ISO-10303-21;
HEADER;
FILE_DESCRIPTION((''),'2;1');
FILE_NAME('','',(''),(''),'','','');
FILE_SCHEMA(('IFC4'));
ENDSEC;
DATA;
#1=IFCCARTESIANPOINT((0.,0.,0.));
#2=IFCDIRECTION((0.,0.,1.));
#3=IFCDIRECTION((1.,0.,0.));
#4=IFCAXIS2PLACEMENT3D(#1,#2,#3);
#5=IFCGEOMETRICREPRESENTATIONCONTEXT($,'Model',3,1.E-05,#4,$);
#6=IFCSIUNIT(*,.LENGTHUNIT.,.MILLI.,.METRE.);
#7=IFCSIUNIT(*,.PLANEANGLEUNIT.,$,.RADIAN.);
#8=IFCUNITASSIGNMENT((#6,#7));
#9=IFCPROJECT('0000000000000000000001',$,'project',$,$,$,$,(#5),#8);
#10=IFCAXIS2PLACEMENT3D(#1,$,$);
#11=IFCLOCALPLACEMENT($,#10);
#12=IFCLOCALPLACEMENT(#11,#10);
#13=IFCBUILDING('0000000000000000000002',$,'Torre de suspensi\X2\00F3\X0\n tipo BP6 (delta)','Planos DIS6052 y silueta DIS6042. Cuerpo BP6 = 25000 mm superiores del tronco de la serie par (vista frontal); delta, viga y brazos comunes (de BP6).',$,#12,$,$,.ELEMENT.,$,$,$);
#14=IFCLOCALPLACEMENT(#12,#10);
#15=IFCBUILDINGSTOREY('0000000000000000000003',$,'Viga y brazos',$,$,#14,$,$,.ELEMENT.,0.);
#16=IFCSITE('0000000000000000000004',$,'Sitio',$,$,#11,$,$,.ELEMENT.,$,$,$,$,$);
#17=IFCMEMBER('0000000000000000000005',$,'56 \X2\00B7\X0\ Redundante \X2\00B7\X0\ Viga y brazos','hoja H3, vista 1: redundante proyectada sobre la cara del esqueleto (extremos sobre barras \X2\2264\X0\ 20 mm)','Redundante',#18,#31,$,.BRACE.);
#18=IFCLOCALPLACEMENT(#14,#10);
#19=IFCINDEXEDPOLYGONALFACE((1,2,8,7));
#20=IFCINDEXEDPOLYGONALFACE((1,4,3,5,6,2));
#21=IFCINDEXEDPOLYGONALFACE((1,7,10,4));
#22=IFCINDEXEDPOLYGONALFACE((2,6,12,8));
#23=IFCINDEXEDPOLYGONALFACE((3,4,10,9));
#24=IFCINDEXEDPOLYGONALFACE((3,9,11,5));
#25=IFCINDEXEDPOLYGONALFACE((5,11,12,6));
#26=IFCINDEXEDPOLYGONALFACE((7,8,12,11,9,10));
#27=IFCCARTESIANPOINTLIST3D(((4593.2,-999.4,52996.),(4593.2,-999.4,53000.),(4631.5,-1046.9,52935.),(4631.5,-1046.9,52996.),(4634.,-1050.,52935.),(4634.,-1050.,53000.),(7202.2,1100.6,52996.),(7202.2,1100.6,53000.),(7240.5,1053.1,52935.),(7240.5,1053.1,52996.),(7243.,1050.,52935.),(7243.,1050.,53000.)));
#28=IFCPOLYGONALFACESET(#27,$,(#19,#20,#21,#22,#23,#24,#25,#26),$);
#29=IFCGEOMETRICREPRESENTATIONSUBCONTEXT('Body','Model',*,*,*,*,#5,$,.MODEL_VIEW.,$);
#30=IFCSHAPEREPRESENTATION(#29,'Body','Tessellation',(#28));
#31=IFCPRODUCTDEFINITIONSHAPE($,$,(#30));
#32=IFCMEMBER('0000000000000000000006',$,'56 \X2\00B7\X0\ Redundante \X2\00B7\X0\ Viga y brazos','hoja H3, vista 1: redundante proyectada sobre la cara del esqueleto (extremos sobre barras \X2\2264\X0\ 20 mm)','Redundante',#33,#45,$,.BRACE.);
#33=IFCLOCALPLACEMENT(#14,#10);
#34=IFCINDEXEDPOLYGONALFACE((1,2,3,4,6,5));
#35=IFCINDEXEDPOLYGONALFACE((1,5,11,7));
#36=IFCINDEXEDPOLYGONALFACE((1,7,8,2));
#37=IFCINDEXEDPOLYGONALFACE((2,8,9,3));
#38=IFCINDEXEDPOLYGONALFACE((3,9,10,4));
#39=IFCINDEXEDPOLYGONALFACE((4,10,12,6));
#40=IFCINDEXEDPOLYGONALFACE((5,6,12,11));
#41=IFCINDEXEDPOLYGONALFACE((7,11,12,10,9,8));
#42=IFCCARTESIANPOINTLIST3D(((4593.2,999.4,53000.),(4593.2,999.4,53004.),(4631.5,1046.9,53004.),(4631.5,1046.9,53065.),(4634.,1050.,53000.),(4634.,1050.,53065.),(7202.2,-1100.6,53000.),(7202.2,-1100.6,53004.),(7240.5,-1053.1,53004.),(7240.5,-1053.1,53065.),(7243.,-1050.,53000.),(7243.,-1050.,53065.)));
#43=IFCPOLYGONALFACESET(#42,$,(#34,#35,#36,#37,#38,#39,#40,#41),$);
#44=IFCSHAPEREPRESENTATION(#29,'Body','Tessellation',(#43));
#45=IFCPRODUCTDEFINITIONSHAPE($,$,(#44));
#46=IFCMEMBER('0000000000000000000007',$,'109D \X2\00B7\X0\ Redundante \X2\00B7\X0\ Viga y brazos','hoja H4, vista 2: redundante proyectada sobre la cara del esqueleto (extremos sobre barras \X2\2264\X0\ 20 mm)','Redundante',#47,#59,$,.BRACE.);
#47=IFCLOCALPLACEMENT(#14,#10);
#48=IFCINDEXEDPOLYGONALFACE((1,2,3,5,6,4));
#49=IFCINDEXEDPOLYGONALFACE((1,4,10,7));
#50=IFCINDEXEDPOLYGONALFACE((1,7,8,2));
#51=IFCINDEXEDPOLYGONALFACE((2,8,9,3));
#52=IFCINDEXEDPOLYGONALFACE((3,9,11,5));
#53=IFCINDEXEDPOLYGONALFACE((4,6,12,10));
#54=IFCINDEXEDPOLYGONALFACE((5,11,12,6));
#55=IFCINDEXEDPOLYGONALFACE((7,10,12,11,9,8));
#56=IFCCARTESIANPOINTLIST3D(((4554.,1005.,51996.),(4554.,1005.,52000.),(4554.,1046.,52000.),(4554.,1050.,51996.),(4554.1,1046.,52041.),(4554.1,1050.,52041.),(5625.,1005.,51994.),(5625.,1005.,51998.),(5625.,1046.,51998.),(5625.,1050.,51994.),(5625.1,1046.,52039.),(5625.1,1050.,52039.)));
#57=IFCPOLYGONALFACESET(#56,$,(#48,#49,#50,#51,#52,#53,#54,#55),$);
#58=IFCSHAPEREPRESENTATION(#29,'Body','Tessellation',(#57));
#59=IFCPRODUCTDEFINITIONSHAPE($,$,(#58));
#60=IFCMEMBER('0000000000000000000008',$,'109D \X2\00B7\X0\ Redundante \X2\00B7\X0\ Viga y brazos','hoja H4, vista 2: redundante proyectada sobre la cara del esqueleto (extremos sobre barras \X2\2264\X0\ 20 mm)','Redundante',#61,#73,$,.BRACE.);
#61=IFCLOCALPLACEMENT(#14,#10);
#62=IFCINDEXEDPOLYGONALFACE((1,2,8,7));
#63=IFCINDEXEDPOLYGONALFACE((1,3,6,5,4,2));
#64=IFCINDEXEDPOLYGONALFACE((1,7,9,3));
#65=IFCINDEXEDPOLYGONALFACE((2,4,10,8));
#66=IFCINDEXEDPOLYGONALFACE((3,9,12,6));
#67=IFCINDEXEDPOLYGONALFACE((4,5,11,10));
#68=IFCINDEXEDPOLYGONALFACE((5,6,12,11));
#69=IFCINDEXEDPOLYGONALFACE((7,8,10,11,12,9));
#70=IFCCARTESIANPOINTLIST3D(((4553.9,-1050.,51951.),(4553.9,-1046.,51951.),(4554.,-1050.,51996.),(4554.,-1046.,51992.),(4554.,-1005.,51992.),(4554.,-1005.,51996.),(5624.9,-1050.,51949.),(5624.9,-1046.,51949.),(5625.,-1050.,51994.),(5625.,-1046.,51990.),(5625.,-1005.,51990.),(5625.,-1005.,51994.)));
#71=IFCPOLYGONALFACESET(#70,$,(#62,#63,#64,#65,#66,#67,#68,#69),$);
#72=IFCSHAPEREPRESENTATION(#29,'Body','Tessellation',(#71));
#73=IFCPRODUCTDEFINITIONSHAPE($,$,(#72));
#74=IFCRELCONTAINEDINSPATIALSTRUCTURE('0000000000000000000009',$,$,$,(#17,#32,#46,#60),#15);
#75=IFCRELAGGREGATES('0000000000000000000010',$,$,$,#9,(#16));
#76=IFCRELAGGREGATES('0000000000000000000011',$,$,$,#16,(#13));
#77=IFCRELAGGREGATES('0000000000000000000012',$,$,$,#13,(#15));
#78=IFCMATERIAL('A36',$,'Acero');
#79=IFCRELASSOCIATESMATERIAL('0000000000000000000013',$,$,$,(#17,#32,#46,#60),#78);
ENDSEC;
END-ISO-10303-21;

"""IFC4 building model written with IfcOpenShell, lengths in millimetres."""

from ifc_helpers import new_model, si_unit, frame, frame_2d, origin, origin_with_axes, place, context, subcontext, project, spatial, l_section, extrude, material, element, save


model = new_model("IFC4")

# Units and contexts
model_context = context("Model", 3, precision=1e-05, world=origin_with_axes())
body_context = subcontext(model_context, "Body", "Model", "MODEL_VIEW")
ifc_project = project(units=[si_unit("LENGTHUNIT", "METRE", prefix="MILLI"), si_unit("PLANEANGLEUNIT", "RADIAN")], contexts=[model_context])

# Site, building, storey
site_placement = place(None, origin())
site = spatial("IfcSite", under=ifc_project, at=site_placement, Name="Sitio", CompositionType="ELEMENT")
building_placement = place(site_placement, origin())
building = spatial("IfcBuilding", under=site, at=building_placement, Name="Torre de suspensión tipo BP6 (delta)", Description="Planos DIS6052 y silueta DIS6042. Cuerpo BP6 = 25000 mm superiores del tronco de la serie par (vista frontal); delta, viga y brazos comunes (de BP6).", CompositionType="ELEMENT")
storey_placement = place(building_placement, origin())
storey = spatial("IfcBuildingStorey", under=building, at=storey_placement, Name="Viga y brazos", CompositionType="ELEMENT", Elevation=0.0)

# Members
ifc_material_1 = material(Name="A36", Category="Acero")
for number, where, z_axis, x_axis, name in (
    (1, (7243.0, 1050.0, 53000.0), (-0.779001, -0.627023, 0.0), (-0.627023, 0.779001, 0.0), "56 · Redundante · Viga y brazos"),
    (2, (7243.0, -1050.0, 53000.0), (-0.779001, 0.627023, 0.0), (-0.627023, -0.779001, 0.0), "56 · Redundante · Viga y brazos"),
):
    element("IfcMember", number, at=place(storey_placement, frame(where, z_axis=z_axis, x_axis=x_axis)), inside=storey, material=ifc_material_1, Name=name, Description="hoja H3, vista 1: redundante proyectada sobre la cara del esqueleto (extremos sobre barras ≤ 20 mm)", ObjectType="Redundante", PredefinedType="BRACE", context=body_context, shape_type="SweptSolid", body=[
        extrude(l_section(Depth=65.0, Width=65.0, Thickness=4.0, at=frame_2d((32.5, 32.5))), None, (0.0, 0.0, 1.0), 3349.2),
    ])
for number, where, z_axis, x_axis, name in (
    (3, (5625.0, 1050.0, 51994.0), (-0.999998, 0.0, 0.001867), (0.0, -1.0, 0.0), "109D · Redundante · Viga y brazos"),
    (4, (5625.0, -1050.0, 51994.0), (-0.999998, 0.0, 0.001867), (0.0, 1.0, 0.0), "109D · Redundante · Viga y brazos"),
):
    element("IfcMember", number, at=place(storey_placement, frame(where, z_axis=z_axis, x_axis=x_axis)), inside=storey, material=ifc_material_1, Name=name, Description="hoja H4, vista 2: redundante proyectada sobre la cara del esqueleto (extremos sobre barras ≤ 20 mm)", ObjectType="Redundante", PredefinedType="BRACE", context=body_context, shape_type="SweptSolid", body=[
        extrude(l_section(Depth=45.0, Width=45.0, Thickness=4.0, at=frame_2d((22.5, 22.5))), None, (0.0, 0.0, 1.0), 1071.0),
    ])

save(model, "model.ifc")
